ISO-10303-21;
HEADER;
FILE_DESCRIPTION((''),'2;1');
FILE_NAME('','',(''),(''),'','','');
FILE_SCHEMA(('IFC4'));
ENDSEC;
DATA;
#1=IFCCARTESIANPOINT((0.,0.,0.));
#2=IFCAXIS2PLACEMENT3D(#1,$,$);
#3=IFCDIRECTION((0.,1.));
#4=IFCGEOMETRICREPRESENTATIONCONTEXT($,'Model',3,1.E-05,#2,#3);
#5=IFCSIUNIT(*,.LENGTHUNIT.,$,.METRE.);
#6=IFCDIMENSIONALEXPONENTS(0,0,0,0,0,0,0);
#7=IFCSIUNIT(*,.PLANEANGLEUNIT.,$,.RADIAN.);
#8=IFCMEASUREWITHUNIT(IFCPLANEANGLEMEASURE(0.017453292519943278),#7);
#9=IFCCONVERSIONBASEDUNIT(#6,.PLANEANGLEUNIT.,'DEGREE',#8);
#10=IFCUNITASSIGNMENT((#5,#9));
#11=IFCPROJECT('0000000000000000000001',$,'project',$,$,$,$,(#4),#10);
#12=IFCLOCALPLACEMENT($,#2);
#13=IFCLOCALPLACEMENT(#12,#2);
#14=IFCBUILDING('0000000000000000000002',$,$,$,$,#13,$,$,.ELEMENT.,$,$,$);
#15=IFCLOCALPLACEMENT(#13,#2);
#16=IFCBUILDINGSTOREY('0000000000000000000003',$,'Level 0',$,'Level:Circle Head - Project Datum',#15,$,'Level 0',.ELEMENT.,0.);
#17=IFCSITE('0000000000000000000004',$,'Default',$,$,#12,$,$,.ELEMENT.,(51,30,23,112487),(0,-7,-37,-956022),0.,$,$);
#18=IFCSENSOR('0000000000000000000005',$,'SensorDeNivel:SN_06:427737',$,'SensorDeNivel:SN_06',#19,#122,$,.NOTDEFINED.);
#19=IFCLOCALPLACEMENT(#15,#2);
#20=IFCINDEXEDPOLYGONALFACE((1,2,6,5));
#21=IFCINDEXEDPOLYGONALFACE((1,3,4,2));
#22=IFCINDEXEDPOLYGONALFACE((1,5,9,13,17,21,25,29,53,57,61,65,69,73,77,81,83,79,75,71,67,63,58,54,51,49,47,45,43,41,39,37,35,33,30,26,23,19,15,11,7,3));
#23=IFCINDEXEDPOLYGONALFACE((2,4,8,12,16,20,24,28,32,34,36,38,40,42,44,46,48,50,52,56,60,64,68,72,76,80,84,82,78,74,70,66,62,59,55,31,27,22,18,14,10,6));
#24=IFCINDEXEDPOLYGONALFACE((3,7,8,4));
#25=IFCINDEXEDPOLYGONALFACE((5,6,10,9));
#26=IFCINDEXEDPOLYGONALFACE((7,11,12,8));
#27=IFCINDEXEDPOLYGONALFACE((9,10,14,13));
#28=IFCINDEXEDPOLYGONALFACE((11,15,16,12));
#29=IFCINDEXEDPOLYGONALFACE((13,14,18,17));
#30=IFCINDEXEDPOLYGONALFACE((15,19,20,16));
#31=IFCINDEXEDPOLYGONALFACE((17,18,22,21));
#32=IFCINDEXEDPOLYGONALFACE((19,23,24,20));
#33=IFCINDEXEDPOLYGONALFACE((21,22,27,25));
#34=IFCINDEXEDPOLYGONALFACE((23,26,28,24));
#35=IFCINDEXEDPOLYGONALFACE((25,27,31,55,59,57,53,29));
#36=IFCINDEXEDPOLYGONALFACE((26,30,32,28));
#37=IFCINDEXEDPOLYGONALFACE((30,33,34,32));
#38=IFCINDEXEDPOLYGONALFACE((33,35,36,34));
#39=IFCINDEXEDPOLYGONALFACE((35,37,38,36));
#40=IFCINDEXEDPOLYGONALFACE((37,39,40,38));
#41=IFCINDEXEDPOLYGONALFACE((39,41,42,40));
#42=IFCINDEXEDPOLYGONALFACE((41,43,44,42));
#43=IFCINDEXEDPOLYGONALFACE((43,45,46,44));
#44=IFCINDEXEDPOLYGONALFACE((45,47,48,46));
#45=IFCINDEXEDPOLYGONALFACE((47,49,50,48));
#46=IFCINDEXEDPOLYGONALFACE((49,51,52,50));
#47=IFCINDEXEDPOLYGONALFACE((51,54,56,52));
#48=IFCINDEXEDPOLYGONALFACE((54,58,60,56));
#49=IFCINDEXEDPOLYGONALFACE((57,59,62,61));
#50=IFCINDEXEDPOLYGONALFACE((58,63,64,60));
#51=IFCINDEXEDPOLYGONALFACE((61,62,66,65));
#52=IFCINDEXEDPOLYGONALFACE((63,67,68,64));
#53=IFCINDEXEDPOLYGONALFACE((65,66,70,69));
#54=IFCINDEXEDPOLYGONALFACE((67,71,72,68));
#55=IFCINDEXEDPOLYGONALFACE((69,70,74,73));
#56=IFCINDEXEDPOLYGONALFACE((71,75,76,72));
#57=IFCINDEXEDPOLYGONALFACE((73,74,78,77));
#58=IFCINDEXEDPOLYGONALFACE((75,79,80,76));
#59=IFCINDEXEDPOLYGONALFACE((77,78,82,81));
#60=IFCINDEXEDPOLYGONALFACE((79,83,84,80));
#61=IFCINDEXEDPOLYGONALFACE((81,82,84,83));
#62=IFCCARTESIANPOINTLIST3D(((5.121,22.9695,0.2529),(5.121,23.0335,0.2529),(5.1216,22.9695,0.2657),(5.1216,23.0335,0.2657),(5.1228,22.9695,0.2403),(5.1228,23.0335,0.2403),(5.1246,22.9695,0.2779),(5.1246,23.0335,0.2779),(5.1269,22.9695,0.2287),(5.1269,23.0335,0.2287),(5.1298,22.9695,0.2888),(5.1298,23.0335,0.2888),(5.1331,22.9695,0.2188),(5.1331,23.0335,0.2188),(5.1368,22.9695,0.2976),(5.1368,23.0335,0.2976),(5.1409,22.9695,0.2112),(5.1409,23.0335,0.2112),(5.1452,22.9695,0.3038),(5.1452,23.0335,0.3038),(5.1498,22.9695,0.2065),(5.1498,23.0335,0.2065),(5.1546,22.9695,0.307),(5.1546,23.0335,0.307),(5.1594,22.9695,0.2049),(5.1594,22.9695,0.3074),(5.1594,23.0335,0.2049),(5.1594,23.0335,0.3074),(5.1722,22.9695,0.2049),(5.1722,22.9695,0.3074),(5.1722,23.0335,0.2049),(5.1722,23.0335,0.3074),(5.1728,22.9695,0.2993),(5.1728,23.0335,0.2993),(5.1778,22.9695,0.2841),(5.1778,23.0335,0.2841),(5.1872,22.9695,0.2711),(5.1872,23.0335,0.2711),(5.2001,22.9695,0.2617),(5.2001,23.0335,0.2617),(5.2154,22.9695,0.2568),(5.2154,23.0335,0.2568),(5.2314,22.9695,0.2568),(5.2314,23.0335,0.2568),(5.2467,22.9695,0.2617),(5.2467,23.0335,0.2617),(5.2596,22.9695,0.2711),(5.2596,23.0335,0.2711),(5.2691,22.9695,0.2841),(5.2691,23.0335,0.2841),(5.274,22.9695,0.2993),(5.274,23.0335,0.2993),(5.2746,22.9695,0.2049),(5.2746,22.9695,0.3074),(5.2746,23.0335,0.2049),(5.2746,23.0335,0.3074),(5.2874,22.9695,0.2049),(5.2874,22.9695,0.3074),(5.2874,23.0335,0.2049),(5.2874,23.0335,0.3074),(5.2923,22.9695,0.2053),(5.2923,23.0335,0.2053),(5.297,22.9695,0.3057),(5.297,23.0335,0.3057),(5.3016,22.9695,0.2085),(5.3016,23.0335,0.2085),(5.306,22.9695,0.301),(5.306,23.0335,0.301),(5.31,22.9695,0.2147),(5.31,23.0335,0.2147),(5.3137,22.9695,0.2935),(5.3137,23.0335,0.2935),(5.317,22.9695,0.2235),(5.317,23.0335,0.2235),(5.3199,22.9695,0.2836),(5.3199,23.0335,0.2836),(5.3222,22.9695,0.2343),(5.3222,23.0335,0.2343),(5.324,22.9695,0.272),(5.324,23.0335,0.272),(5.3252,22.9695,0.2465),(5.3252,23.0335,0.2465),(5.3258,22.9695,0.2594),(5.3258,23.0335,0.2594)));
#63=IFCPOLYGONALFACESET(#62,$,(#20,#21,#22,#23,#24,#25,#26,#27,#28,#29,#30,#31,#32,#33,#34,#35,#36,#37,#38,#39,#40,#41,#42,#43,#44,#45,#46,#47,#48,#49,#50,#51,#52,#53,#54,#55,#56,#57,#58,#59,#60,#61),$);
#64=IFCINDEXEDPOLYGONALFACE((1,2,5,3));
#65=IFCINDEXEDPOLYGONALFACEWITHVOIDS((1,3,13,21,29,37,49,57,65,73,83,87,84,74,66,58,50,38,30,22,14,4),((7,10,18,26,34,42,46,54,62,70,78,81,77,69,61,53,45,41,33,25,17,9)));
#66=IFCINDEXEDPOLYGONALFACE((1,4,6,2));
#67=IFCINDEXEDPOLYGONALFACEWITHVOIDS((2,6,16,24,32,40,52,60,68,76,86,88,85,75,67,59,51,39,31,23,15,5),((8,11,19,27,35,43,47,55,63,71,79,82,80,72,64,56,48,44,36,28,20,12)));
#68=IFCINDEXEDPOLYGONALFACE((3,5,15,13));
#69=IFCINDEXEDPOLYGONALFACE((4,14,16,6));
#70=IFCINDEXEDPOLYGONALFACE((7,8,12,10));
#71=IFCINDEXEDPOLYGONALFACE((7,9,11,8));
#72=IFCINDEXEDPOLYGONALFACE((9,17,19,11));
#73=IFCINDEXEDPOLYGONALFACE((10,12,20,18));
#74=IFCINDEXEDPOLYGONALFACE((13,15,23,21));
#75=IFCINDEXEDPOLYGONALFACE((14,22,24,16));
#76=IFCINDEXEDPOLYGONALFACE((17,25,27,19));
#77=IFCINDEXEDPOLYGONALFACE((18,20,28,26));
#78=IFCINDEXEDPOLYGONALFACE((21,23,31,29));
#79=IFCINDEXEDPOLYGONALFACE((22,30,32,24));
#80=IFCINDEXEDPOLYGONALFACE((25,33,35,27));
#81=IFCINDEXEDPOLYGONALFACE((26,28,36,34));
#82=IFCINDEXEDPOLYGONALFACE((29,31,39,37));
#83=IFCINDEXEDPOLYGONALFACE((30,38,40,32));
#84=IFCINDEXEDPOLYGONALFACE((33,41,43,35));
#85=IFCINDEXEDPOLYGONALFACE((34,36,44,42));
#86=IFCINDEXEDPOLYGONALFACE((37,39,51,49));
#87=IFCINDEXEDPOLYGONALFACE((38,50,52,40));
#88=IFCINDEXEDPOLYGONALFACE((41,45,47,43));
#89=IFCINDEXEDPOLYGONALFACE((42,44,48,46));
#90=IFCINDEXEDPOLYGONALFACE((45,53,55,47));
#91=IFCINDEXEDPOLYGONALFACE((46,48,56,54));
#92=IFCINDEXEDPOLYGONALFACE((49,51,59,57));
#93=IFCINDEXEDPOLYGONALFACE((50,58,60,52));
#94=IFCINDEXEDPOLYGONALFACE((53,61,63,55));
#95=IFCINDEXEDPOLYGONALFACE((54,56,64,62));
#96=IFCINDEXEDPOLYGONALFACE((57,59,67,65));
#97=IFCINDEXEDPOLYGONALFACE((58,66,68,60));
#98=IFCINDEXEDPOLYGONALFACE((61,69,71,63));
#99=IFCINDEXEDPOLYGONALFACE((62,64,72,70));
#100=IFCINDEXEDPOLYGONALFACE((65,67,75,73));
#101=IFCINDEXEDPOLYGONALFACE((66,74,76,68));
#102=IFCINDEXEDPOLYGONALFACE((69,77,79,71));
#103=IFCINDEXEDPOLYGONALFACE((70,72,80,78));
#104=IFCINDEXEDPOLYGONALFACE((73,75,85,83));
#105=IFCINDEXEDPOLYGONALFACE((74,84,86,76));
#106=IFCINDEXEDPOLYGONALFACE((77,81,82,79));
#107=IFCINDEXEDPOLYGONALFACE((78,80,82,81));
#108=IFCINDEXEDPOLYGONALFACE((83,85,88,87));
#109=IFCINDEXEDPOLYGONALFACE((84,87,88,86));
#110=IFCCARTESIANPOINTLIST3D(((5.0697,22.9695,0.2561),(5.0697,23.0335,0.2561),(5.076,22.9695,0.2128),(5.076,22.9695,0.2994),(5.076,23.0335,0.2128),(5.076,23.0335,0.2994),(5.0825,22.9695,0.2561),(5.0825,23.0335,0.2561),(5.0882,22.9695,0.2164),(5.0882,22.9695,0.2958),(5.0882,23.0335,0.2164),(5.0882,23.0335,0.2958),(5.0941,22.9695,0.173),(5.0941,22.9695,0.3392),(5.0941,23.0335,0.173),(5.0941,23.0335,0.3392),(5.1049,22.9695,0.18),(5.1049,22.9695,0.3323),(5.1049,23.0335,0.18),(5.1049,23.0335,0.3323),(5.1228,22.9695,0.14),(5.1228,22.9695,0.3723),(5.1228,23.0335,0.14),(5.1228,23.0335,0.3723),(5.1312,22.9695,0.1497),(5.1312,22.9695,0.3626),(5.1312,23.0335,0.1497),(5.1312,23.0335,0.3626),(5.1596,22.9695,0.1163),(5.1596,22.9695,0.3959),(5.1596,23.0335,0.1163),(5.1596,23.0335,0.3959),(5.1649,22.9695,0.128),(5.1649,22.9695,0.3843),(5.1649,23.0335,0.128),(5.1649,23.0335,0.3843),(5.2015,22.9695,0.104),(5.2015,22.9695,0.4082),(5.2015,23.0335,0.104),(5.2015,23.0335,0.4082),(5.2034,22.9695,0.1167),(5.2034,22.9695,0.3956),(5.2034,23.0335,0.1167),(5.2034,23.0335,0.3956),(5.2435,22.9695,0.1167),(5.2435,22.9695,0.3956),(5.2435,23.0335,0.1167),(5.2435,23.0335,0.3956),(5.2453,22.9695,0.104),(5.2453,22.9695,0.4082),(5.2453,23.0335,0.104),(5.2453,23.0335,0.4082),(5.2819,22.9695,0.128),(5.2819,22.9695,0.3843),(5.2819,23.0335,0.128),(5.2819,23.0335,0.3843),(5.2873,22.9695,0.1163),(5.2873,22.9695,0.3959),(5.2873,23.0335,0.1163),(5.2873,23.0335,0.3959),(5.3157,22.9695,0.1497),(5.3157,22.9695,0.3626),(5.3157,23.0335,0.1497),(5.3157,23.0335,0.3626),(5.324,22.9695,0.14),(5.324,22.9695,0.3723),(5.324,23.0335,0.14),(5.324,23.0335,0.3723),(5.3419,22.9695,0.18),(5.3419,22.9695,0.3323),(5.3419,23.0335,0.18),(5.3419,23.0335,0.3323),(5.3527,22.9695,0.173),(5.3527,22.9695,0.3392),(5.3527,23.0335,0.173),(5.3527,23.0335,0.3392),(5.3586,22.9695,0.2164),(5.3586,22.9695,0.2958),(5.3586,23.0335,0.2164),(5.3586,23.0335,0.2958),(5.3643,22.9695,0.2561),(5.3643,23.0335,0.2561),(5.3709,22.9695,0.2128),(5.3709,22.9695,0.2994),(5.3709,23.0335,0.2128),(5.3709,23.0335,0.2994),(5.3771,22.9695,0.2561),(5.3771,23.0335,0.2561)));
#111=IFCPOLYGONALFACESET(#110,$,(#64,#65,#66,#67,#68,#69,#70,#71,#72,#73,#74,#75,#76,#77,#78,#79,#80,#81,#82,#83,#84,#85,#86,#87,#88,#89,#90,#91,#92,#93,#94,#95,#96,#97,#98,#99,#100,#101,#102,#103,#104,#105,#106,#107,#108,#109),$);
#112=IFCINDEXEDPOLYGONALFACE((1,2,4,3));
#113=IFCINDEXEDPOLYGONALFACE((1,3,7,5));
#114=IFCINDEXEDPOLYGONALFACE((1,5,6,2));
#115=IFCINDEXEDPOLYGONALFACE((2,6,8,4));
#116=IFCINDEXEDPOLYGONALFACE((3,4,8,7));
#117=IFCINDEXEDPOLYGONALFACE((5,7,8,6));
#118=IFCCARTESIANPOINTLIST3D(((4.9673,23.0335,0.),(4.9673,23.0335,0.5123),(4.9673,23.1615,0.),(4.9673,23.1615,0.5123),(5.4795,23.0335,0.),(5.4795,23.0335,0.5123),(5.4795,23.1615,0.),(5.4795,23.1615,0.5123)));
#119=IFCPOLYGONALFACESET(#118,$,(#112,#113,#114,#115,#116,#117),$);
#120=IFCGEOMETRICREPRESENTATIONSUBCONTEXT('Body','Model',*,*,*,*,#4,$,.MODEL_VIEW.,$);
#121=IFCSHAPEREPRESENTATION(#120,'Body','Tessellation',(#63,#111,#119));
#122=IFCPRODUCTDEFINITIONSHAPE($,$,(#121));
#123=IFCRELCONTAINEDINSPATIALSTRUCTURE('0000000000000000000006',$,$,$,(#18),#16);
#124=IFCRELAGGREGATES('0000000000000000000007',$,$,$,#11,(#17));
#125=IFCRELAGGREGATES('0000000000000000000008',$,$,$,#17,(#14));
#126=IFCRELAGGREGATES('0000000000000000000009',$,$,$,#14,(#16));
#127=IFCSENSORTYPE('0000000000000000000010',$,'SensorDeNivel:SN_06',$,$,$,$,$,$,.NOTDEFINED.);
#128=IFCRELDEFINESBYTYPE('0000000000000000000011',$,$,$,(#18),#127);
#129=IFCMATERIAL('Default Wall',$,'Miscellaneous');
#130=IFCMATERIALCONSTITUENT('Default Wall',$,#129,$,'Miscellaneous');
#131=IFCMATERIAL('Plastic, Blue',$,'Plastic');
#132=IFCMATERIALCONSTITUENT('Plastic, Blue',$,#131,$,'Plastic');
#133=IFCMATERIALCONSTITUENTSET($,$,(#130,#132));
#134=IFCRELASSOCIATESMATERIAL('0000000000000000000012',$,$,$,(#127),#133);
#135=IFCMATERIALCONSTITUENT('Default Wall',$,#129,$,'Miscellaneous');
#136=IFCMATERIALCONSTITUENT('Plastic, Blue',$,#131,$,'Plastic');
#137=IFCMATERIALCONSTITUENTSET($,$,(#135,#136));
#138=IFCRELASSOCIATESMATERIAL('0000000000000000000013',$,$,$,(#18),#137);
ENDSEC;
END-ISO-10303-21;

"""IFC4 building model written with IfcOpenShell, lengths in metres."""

from ifc_helpers import new_model, entity, si_unit, converted_unit, direction, frame, origin, place, context, subcontext, project, spatial, arc, indexed_curve, outline, extrude, source, transform, mapped, material, constituent, constituent_set, type_object, type_shapes, element, save


model = new_model("IFC4")

# Units and contexts
model_context = context("Model", 3, precision=1e-05, world=origin(), true_north=direction((0.0, 1.0)))
body_context = subcontext(model_context, "Body", "Model", "MODEL_VIEW")
ifc_project = project(units=[si_unit("LENGTHUNIT", "METRE"), converted_unit("PLANEANGLEUNIT", "DEGREE", entity("IfcPlaneAngleMeasure", 0.017453292519943278), si_unit("PLANEANGLEUNIT", "RADIAN"), dimensions=[0, 0, 0, 0, 0, 0, 0])], contexts=[model_context])

# Site, building, storey
site_placement = place(None, origin())
site = spatial("IfcSite", under=ifc_project, at=site_placement, Name="Default", CompositionType="ELEMENT", RefLatitude=(51, 30, 23, 112487), RefLongitude=(0, -7, -37, -956022), RefElevation=0.0)
building_placement = place(site_placement, origin())
building = spatial("IfcBuilding", under=site, at=building_placement, CompositionType="ELEMENT")
storey_placement = place(building_placement, origin())
storey = spatial("IfcBuildingStorey", under=building, at=storey_placement, Name="Level 0", ObjectType="Level:Circle Head - Project Datum", LongName="Level 0", CompositionType="ELEMENT", Elevation=0.0)

# Sensor
ifc_material_1 = material(Name="Default Wall", Category="Miscellaneous")
ifc_constituent_1 = constituent(ifc_material_1, Name="Default Wall", Category="Miscellaneous")
ifc_material_2 = material(Name="Plastic, Blue", Category="Plastic")
ifc_constituent_2 = constituent(ifc_material_2, Name="Plastic, Blue", Category="Plastic")
ifc_constituent_set_1 = constituent_set(constituents=[ifc_constituent_1, ifc_constituent_2])
ifc_constituent_3 = constituent(ifc_material_1, Name="Default Wall", Category="Miscellaneous")
ifc_constituent_4 = constituent(ifc_material_2, Name="Plastic, Blue", Category="Plastic")
ifc_constituent_set_2 = constituent_set(constituents=[ifc_constituent_3, ifc_constituent_4])
sensor_type_1 = type_object("IfcSensorType", Name="SensorDeNivel:SN_06", PredefinedType="NOTDEFINED", material=ifc_constituent_set_2)
shared_shape_1 = source(origin(), body_context, "Body", "SweptSolid", [
    extrude(outline(indexed_curve([(0.0512, -0.0556), (0.064, -0.0556), (0.0736, -0.054), (0.0825, -0.0493), (0.0903, -0.0417), (0.0965, -0.0318), (0.1006, -0.0202), (0.1024, -0.0076), (0.1018, 0.0052), (0.0988, 0.0174), (0.0936, 0.0283), (0.0866, 0.037), (0.0782, 0.0432), (0.0689, 0.0464), (0.064, 0.0468), (0.0512, 0.0468), (0.0506, 0.0388), (0.0456, 0.0236), (0.0362, 0.0106), (0.0233, 0.0012), (0.008, -0.0038), (-0.008, -0.0038), (-0.0233, 0.0012), (-0.0362, 0.0106), (-0.0456, 0.0236), (-0.0506, 0.0388), (-0.0512, 0.0468), (-0.064, 0.0468), (-0.0736, 0.0452), (-0.0825, 0.0405), (-0.0903, 0.0329), (-0.0965, 0.023), (-0.1006, 0.0114), (-0.1024, -0.0012), (-0.1018, -0.014), (-0.0988, -0.0262), (-0.0936, -0.0371), (-0.0866, -0.0458), (-0.0782, -0.052), (-0.0689, -0.0552), (-0.064, -0.0556), (-0.0512, -0.0556), (0.0512, -0.0556)], self_intersect=False)), frame((0.0, -0.1281, 0.2605), z_axis=(0.0, 1.0, 0.0), x_axis=(-1.0, 0.0, 0.0)), (0.0, 0.0, 1.0), 0.064),
    extrude(outline(indexed_curve([(-0.1537, 0.0), (0.0, -0.1537), (0.1537, 0.0), (0.0, 0.1537)], segments=[arc(1, 2, 3), arc(3, 4, 1)], self_intersect=False), holes=[indexed_curve([(-0.1409, 0.0), (0.0, 0.1409), (0.1409, 0.0), (0.0, -0.1409)], segments=[arc(1, 2, 3), arc(3, 4, 1)], self_intersect=False)]), frame((0.0, -0.1281, 0.2561), z_axis=(0.0, 1.0, 0.0), x_axis=(1.0, 0.0, 0.0)), (0.0, 0.0, 1.0), 0.064),
    extrude(outline(indexed_curve([(-0.2561, -0.064), (0.2561, -0.064), (0.2561, 0.064), (-0.2561, 0.064), (-0.2561, -0.064)], self_intersect=False)), frame((0.0, 0.0, 0.0), z_axis=(0.0, 0.0, 1.0), x_axis=(-1.0, 0.0, 0.0)), (0.0, 0.0, 1.0), 0.5123),
])
type_shapes(sensor_type_1, [shared_shape_1])
sensor_1_placement = place(storey_placement, frame((5.2234, 23.0975, 0.0)))
element("IfcSensor", 1, at=sensor_1_placement, inside=storey, type_object=sensor_type_1, material=ifc_constituent_set_1, Name="SensorDeNivel:SN_06:427737", ObjectType="SensorDeNivel:SN_06", PredefinedType="NOTDEFINED", context=body_context, shape_type="MappedRepresentation", body=[
    mapped(shared_shape_1, transform((0.0, 0.0, 0.0), scale=1.0)),
])

save(model, "model.ifc")
